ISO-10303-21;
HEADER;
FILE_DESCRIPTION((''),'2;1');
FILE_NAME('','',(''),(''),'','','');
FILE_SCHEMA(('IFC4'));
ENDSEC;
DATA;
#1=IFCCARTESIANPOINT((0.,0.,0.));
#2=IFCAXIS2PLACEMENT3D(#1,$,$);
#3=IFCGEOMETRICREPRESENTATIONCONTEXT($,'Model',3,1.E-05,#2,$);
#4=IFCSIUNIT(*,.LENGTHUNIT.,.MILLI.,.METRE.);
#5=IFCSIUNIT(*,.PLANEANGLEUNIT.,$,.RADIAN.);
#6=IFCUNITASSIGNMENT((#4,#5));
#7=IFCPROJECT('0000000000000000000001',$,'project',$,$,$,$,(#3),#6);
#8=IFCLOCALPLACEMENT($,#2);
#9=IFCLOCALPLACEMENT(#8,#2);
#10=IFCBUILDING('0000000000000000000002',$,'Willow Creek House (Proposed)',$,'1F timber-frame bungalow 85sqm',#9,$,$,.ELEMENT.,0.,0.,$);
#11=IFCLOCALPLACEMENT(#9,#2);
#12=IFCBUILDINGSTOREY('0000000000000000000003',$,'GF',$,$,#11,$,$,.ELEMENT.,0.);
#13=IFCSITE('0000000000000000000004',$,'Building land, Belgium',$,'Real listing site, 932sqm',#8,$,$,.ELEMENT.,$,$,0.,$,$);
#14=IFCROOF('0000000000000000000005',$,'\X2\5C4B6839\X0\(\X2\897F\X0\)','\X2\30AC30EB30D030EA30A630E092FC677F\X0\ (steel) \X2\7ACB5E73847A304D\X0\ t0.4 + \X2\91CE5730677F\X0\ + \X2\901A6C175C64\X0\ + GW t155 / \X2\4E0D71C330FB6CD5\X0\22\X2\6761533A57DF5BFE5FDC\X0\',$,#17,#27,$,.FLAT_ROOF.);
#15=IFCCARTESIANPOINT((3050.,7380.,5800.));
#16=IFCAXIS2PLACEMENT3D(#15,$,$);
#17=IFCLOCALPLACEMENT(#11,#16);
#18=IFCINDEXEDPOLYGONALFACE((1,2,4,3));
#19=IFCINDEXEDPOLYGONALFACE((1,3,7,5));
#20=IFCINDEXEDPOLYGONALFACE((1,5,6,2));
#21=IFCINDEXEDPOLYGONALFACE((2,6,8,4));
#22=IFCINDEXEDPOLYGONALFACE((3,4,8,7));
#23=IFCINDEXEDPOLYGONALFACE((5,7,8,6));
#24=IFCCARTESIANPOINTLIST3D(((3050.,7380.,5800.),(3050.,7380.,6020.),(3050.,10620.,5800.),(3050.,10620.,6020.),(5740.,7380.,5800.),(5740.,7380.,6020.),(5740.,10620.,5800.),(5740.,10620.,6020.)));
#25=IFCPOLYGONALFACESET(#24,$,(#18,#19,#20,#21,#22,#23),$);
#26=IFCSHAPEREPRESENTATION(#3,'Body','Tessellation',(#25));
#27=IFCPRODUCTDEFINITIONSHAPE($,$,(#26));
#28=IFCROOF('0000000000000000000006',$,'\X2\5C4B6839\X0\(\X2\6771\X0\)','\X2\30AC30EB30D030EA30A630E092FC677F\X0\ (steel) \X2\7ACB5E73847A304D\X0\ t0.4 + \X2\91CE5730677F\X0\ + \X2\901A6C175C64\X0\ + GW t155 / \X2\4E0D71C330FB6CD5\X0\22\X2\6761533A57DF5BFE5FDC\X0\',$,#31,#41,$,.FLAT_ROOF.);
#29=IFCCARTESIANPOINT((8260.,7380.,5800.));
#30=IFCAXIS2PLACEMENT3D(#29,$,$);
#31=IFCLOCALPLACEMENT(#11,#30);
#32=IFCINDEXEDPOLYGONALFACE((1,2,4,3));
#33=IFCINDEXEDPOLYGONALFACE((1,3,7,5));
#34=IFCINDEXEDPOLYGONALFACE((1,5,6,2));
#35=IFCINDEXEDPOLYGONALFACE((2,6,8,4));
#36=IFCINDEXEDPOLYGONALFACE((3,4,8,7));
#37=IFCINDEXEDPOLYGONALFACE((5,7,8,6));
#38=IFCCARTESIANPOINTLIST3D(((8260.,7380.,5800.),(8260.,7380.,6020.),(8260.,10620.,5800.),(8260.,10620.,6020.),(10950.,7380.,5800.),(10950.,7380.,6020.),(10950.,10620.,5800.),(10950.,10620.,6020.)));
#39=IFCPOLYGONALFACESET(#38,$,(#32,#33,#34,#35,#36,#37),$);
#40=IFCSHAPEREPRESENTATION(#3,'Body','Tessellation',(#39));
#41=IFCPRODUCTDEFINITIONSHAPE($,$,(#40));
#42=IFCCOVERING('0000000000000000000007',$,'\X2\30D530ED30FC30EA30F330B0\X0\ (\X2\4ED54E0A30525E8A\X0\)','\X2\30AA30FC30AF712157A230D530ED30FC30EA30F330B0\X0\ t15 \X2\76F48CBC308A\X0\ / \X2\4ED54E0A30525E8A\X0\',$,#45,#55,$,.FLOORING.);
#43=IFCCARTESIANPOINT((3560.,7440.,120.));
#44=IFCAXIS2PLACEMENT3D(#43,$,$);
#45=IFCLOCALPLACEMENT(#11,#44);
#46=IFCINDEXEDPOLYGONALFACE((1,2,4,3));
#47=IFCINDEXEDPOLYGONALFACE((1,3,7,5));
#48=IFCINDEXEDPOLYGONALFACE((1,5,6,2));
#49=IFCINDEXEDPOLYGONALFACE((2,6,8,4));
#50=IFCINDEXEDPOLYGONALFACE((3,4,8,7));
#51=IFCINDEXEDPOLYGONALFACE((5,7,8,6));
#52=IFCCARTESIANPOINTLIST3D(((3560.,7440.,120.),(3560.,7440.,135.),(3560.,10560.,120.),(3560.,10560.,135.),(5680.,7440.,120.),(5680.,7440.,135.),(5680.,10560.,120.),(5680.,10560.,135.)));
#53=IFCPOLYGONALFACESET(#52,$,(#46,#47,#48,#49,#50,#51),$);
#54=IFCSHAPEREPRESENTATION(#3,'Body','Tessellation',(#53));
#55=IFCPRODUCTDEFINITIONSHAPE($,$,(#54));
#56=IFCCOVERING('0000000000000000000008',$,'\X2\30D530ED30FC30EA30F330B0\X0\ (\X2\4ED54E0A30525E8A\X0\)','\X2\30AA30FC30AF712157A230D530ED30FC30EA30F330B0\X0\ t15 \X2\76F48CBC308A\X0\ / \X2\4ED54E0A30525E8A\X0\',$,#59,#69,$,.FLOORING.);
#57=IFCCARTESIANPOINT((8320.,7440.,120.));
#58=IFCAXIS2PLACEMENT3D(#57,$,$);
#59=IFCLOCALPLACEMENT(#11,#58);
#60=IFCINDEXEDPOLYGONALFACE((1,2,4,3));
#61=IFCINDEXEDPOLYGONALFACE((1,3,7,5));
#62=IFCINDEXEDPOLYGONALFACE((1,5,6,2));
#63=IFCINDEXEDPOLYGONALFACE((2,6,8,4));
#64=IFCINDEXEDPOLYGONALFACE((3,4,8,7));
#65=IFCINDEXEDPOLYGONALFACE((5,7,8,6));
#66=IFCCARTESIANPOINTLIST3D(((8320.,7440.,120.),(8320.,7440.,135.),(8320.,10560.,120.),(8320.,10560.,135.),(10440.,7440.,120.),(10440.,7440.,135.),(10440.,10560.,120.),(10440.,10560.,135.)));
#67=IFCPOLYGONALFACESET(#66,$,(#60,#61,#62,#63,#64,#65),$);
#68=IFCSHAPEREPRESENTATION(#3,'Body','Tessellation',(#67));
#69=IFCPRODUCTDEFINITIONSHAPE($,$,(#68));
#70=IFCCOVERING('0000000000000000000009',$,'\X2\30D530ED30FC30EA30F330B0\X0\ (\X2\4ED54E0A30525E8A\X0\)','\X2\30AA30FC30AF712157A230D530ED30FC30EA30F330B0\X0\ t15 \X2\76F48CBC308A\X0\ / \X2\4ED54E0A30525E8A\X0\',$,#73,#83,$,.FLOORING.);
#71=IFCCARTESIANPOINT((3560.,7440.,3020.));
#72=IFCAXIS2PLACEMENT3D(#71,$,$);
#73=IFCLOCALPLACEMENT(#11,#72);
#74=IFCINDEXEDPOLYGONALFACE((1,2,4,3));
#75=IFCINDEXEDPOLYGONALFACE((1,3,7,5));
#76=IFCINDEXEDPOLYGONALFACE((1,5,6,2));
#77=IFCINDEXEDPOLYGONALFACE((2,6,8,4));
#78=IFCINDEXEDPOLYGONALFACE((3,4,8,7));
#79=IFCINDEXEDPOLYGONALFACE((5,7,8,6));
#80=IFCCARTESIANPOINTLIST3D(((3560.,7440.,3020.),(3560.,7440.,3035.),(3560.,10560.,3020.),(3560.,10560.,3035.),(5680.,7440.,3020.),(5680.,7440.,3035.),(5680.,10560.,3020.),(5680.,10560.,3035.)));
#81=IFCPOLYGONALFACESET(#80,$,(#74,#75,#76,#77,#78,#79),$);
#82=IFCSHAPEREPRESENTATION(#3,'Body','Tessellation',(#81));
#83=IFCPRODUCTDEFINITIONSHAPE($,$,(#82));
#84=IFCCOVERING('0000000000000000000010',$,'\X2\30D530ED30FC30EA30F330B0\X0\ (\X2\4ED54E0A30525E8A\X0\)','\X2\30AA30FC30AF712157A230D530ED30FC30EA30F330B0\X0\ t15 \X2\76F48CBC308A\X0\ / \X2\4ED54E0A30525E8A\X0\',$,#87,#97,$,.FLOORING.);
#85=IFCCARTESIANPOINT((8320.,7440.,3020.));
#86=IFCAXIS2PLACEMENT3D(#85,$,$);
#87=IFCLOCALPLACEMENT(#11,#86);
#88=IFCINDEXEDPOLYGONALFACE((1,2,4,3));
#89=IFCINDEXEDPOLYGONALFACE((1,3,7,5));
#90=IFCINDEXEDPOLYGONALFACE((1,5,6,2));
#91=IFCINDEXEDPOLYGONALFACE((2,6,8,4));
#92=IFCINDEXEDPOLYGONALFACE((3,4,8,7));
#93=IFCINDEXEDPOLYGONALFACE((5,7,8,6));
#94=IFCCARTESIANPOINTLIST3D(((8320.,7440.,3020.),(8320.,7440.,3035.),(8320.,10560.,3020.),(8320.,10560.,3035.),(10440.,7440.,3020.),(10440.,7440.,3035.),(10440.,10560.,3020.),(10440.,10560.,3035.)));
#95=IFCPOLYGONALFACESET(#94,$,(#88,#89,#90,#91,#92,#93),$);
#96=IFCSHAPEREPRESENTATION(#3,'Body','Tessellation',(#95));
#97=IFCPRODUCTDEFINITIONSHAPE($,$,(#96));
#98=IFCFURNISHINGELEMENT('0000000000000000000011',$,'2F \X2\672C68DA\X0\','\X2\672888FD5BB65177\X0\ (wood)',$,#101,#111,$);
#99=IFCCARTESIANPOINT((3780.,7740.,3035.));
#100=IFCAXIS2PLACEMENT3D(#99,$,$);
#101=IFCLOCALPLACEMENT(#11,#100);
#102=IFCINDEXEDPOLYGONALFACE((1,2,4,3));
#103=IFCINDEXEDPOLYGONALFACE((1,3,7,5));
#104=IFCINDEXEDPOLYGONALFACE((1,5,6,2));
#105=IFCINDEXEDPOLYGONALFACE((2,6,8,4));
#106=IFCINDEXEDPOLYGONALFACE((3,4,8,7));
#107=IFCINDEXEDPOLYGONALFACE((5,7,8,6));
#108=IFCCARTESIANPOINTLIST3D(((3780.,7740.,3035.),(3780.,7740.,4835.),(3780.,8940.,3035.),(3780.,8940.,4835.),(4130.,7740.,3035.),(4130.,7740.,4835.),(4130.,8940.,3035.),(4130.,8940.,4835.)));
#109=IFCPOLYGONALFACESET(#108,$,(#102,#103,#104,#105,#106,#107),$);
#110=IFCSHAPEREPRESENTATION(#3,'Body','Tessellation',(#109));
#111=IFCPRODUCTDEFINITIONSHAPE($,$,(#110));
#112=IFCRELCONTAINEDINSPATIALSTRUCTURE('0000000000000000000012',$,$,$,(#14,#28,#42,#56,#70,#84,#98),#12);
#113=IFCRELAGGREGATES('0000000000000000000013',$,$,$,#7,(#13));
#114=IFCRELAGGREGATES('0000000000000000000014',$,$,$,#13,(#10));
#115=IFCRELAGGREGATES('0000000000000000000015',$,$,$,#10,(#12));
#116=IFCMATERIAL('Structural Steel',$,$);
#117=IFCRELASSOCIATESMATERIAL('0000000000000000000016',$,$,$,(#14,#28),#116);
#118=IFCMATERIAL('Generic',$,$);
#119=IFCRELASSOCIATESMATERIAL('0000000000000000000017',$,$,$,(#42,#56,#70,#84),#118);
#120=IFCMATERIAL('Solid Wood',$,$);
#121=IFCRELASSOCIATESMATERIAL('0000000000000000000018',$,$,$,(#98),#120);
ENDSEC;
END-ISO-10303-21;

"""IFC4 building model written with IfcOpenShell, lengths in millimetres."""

from ifc_helpers import new_model, si_unit, frame, frame_2d, origin, place, context, project, spatial, rectangle, extrude, material, element, save


model = new_model("IFC4")

# Units and contexts
model_context = context("Model", 3, precision=1e-05, world=origin())
ifc_project = project(units=[si_unit("LENGTHUNIT", "METRE", prefix="MILLI"), si_unit("PLANEANGLEUNIT", "RADIAN")], contexts=[model_context])

# Site, building, storey
site_placement = place(None, origin())
site = spatial("IfcSite", under=ifc_project, at=site_placement, Name="Building land, Belgium", ObjectType="Real listing site, 932sqm", CompositionType="ELEMENT", RefElevation=0.0)
building_placement = place(site_placement, origin())
building = spatial("IfcBuilding", under=site, at=building_placement, Name="Willow Creek House (Proposed)", ObjectType="1F timber-frame bungalow 85sqm", CompositionType="ELEMENT", ElevationOfRefHeight=0.0, ElevationOfTerrain=0.0)
storey_placement = place(building_placement, origin())
storey = spatial("IfcBuildingStorey", under=building, at=storey_placement, Name="GF", CompositionType="ELEMENT", Elevation=0.0)

# Shared definitions
ifc_material_1 = material(Name="Solid Wood")

# Shared definitions
ifc_material_2 = material(Name="Generic")

# Roofs
ifc_material_3 = material(Name="Structural Steel")
roof_1_placement = place(storey_placement, frame((3050.0, 7380.0, 5800.0)))
element("IfcRoof", 1, at=roof_1_placement, inside=storey, material=ifc_material_3, Name="屋根(西)", Description="ガルバリウム鋼板 (steel) 立平葺き t0.4 + 野地板 + 通気層 + GW t155 / 不燃・法22条区域対応", PredefinedType="FLAT_ROOF", context=model_context, shape_type="SweptSolid", body=[
    extrude(rectangle(XDim=2690.0, YDim=3240.0, at=frame_2d((1345.0, 1620.0))), frame((3050.0, 7380.0, 5800.0)), (0.0, 0.0, 1.0), 220.0),
])
roof_2_placement = place(storey_placement, frame((8260.0, 7380.0, 5800.0)))
element("IfcRoof", 2, at=roof_2_placement, inside=storey, material=ifc_material_3, Name="屋根(東)", Description="ガルバリウム鋼板 (steel) 立平葺き t0.4 + 野地板 + 通気層 + GW t155 / 不燃・法22条区域対応", PredefinedType="FLAT_ROOF", context=model_context, shape_type="SweptSolid", body=[
    extrude(rectangle(XDim=2690.0, YDim=3240.0, at=frame_2d((1345.0, 1620.0))), frame((8260.0, 7380.0, 5800.0)), (0.0, 0.0, 1.0), 220.0),
])

# Coverings
covering_1_placement = place(storey_placement, frame((3560.0, 7440.0, 120.0)))
element("IfcCovering", 3, at=covering_1_placement, inside=storey, material=ifc_material_2, Name="フローリング (仕上げ床)", Description="オーク無垢フローリング t15 直貼り / 仕上げ床", PredefinedType="FLOORING", context=model_context, shape_type="SweptSolid", body=[
    extrude(rectangle(XDim=2120.0, YDim=3120.0, at=frame_2d((1060.0, 1560.0))), frame((3560.0, 7440.0, 120.0)), (0.0, 0.0, 1.0), 15.0),
])
covering_2_placement = place(storey_placement, frame((8320.0, 7440.0, 120.0)))
element("IfcCovering", 4, at=covering_2_placement, inside=storey, material=ifc_material_2, Name="フローリング (仕上げ床)", Description="オーク無垢フローリング t15 直貼り / 仕上げ床", PredefinedType="FLOORING", context=model_context, shape_type="SweptSolid", body=[
    extrude(rectangle(XDim=2120.0, YDim=3120.0, at=frame_2d((1060.0, 1560.0))), frame((8320.0, 7440.0, 120.0)), (0.0, 0.0, 1.0), 15.0),
])
covering_3_placement = place(storey_placement, frame((3560.0, 7440.0, 3020.0)))
element("IfcCovering", 5, at=covering_3_placement, inside=storey, material=ifc_material_2, Name="フローリング (仕上げ床)", Description="オーク無垢フローリング t15 直貼り / 仕上げ床", PredefinedType="FLOORING", context=model_context, shape_type="SweptSolid", body=[
    extrude(rectangle(XDim=2120.0, YDim=3120.0, at=frame_2d((1060.0, 1560.0))), frame((3560.0, 7440.0, 3020.0)), (0.0, 0.0, 1.0), 15.0),
])
covering_4_placement = place(storey_placement, frame((8320.0, 7440.0, 3020.0)))
element("IfcCovering", 6, at=covering_4_placement, inside=storey, material=ifc_material_2, Name="フローリング (仕上げ床)", Description="オーク無垢フローリング t15 直貼り / 仕上げ床", PredefinedType="FLOORING", context=model_context, shape_type="SweptSolid", body=[
    extrude(rectangle(XDim=2120.0, YDim=3120.0, at=frame_2d((1060.0, 1560.0))), frame((8320.0, 7440.0, 3020.0)), (0.0, 0.0, 1.0), 15.0),
])

# Furnishing element
furnishing_placement = place(storey_placement, frame((3780.0, 7740.0, 3035.0)))
element("IfcFurnishingElement", 7, at=furnishing_placement, inside=storey, material=ifc_material_1, Name="2F 本棚", Description="木製家具 (wood)", context=model_context, shape_type="SweptSolid", body=[
    extrude(rectangle(XDim=350.0, YDim=1200.0, at=frame_2d((175.0, 600.0))), frame((3780.0, 7740.0, 3035.0)), (0.0, 0.0, 1.0), 1800.0),
])

save(model, "model.ifc")
